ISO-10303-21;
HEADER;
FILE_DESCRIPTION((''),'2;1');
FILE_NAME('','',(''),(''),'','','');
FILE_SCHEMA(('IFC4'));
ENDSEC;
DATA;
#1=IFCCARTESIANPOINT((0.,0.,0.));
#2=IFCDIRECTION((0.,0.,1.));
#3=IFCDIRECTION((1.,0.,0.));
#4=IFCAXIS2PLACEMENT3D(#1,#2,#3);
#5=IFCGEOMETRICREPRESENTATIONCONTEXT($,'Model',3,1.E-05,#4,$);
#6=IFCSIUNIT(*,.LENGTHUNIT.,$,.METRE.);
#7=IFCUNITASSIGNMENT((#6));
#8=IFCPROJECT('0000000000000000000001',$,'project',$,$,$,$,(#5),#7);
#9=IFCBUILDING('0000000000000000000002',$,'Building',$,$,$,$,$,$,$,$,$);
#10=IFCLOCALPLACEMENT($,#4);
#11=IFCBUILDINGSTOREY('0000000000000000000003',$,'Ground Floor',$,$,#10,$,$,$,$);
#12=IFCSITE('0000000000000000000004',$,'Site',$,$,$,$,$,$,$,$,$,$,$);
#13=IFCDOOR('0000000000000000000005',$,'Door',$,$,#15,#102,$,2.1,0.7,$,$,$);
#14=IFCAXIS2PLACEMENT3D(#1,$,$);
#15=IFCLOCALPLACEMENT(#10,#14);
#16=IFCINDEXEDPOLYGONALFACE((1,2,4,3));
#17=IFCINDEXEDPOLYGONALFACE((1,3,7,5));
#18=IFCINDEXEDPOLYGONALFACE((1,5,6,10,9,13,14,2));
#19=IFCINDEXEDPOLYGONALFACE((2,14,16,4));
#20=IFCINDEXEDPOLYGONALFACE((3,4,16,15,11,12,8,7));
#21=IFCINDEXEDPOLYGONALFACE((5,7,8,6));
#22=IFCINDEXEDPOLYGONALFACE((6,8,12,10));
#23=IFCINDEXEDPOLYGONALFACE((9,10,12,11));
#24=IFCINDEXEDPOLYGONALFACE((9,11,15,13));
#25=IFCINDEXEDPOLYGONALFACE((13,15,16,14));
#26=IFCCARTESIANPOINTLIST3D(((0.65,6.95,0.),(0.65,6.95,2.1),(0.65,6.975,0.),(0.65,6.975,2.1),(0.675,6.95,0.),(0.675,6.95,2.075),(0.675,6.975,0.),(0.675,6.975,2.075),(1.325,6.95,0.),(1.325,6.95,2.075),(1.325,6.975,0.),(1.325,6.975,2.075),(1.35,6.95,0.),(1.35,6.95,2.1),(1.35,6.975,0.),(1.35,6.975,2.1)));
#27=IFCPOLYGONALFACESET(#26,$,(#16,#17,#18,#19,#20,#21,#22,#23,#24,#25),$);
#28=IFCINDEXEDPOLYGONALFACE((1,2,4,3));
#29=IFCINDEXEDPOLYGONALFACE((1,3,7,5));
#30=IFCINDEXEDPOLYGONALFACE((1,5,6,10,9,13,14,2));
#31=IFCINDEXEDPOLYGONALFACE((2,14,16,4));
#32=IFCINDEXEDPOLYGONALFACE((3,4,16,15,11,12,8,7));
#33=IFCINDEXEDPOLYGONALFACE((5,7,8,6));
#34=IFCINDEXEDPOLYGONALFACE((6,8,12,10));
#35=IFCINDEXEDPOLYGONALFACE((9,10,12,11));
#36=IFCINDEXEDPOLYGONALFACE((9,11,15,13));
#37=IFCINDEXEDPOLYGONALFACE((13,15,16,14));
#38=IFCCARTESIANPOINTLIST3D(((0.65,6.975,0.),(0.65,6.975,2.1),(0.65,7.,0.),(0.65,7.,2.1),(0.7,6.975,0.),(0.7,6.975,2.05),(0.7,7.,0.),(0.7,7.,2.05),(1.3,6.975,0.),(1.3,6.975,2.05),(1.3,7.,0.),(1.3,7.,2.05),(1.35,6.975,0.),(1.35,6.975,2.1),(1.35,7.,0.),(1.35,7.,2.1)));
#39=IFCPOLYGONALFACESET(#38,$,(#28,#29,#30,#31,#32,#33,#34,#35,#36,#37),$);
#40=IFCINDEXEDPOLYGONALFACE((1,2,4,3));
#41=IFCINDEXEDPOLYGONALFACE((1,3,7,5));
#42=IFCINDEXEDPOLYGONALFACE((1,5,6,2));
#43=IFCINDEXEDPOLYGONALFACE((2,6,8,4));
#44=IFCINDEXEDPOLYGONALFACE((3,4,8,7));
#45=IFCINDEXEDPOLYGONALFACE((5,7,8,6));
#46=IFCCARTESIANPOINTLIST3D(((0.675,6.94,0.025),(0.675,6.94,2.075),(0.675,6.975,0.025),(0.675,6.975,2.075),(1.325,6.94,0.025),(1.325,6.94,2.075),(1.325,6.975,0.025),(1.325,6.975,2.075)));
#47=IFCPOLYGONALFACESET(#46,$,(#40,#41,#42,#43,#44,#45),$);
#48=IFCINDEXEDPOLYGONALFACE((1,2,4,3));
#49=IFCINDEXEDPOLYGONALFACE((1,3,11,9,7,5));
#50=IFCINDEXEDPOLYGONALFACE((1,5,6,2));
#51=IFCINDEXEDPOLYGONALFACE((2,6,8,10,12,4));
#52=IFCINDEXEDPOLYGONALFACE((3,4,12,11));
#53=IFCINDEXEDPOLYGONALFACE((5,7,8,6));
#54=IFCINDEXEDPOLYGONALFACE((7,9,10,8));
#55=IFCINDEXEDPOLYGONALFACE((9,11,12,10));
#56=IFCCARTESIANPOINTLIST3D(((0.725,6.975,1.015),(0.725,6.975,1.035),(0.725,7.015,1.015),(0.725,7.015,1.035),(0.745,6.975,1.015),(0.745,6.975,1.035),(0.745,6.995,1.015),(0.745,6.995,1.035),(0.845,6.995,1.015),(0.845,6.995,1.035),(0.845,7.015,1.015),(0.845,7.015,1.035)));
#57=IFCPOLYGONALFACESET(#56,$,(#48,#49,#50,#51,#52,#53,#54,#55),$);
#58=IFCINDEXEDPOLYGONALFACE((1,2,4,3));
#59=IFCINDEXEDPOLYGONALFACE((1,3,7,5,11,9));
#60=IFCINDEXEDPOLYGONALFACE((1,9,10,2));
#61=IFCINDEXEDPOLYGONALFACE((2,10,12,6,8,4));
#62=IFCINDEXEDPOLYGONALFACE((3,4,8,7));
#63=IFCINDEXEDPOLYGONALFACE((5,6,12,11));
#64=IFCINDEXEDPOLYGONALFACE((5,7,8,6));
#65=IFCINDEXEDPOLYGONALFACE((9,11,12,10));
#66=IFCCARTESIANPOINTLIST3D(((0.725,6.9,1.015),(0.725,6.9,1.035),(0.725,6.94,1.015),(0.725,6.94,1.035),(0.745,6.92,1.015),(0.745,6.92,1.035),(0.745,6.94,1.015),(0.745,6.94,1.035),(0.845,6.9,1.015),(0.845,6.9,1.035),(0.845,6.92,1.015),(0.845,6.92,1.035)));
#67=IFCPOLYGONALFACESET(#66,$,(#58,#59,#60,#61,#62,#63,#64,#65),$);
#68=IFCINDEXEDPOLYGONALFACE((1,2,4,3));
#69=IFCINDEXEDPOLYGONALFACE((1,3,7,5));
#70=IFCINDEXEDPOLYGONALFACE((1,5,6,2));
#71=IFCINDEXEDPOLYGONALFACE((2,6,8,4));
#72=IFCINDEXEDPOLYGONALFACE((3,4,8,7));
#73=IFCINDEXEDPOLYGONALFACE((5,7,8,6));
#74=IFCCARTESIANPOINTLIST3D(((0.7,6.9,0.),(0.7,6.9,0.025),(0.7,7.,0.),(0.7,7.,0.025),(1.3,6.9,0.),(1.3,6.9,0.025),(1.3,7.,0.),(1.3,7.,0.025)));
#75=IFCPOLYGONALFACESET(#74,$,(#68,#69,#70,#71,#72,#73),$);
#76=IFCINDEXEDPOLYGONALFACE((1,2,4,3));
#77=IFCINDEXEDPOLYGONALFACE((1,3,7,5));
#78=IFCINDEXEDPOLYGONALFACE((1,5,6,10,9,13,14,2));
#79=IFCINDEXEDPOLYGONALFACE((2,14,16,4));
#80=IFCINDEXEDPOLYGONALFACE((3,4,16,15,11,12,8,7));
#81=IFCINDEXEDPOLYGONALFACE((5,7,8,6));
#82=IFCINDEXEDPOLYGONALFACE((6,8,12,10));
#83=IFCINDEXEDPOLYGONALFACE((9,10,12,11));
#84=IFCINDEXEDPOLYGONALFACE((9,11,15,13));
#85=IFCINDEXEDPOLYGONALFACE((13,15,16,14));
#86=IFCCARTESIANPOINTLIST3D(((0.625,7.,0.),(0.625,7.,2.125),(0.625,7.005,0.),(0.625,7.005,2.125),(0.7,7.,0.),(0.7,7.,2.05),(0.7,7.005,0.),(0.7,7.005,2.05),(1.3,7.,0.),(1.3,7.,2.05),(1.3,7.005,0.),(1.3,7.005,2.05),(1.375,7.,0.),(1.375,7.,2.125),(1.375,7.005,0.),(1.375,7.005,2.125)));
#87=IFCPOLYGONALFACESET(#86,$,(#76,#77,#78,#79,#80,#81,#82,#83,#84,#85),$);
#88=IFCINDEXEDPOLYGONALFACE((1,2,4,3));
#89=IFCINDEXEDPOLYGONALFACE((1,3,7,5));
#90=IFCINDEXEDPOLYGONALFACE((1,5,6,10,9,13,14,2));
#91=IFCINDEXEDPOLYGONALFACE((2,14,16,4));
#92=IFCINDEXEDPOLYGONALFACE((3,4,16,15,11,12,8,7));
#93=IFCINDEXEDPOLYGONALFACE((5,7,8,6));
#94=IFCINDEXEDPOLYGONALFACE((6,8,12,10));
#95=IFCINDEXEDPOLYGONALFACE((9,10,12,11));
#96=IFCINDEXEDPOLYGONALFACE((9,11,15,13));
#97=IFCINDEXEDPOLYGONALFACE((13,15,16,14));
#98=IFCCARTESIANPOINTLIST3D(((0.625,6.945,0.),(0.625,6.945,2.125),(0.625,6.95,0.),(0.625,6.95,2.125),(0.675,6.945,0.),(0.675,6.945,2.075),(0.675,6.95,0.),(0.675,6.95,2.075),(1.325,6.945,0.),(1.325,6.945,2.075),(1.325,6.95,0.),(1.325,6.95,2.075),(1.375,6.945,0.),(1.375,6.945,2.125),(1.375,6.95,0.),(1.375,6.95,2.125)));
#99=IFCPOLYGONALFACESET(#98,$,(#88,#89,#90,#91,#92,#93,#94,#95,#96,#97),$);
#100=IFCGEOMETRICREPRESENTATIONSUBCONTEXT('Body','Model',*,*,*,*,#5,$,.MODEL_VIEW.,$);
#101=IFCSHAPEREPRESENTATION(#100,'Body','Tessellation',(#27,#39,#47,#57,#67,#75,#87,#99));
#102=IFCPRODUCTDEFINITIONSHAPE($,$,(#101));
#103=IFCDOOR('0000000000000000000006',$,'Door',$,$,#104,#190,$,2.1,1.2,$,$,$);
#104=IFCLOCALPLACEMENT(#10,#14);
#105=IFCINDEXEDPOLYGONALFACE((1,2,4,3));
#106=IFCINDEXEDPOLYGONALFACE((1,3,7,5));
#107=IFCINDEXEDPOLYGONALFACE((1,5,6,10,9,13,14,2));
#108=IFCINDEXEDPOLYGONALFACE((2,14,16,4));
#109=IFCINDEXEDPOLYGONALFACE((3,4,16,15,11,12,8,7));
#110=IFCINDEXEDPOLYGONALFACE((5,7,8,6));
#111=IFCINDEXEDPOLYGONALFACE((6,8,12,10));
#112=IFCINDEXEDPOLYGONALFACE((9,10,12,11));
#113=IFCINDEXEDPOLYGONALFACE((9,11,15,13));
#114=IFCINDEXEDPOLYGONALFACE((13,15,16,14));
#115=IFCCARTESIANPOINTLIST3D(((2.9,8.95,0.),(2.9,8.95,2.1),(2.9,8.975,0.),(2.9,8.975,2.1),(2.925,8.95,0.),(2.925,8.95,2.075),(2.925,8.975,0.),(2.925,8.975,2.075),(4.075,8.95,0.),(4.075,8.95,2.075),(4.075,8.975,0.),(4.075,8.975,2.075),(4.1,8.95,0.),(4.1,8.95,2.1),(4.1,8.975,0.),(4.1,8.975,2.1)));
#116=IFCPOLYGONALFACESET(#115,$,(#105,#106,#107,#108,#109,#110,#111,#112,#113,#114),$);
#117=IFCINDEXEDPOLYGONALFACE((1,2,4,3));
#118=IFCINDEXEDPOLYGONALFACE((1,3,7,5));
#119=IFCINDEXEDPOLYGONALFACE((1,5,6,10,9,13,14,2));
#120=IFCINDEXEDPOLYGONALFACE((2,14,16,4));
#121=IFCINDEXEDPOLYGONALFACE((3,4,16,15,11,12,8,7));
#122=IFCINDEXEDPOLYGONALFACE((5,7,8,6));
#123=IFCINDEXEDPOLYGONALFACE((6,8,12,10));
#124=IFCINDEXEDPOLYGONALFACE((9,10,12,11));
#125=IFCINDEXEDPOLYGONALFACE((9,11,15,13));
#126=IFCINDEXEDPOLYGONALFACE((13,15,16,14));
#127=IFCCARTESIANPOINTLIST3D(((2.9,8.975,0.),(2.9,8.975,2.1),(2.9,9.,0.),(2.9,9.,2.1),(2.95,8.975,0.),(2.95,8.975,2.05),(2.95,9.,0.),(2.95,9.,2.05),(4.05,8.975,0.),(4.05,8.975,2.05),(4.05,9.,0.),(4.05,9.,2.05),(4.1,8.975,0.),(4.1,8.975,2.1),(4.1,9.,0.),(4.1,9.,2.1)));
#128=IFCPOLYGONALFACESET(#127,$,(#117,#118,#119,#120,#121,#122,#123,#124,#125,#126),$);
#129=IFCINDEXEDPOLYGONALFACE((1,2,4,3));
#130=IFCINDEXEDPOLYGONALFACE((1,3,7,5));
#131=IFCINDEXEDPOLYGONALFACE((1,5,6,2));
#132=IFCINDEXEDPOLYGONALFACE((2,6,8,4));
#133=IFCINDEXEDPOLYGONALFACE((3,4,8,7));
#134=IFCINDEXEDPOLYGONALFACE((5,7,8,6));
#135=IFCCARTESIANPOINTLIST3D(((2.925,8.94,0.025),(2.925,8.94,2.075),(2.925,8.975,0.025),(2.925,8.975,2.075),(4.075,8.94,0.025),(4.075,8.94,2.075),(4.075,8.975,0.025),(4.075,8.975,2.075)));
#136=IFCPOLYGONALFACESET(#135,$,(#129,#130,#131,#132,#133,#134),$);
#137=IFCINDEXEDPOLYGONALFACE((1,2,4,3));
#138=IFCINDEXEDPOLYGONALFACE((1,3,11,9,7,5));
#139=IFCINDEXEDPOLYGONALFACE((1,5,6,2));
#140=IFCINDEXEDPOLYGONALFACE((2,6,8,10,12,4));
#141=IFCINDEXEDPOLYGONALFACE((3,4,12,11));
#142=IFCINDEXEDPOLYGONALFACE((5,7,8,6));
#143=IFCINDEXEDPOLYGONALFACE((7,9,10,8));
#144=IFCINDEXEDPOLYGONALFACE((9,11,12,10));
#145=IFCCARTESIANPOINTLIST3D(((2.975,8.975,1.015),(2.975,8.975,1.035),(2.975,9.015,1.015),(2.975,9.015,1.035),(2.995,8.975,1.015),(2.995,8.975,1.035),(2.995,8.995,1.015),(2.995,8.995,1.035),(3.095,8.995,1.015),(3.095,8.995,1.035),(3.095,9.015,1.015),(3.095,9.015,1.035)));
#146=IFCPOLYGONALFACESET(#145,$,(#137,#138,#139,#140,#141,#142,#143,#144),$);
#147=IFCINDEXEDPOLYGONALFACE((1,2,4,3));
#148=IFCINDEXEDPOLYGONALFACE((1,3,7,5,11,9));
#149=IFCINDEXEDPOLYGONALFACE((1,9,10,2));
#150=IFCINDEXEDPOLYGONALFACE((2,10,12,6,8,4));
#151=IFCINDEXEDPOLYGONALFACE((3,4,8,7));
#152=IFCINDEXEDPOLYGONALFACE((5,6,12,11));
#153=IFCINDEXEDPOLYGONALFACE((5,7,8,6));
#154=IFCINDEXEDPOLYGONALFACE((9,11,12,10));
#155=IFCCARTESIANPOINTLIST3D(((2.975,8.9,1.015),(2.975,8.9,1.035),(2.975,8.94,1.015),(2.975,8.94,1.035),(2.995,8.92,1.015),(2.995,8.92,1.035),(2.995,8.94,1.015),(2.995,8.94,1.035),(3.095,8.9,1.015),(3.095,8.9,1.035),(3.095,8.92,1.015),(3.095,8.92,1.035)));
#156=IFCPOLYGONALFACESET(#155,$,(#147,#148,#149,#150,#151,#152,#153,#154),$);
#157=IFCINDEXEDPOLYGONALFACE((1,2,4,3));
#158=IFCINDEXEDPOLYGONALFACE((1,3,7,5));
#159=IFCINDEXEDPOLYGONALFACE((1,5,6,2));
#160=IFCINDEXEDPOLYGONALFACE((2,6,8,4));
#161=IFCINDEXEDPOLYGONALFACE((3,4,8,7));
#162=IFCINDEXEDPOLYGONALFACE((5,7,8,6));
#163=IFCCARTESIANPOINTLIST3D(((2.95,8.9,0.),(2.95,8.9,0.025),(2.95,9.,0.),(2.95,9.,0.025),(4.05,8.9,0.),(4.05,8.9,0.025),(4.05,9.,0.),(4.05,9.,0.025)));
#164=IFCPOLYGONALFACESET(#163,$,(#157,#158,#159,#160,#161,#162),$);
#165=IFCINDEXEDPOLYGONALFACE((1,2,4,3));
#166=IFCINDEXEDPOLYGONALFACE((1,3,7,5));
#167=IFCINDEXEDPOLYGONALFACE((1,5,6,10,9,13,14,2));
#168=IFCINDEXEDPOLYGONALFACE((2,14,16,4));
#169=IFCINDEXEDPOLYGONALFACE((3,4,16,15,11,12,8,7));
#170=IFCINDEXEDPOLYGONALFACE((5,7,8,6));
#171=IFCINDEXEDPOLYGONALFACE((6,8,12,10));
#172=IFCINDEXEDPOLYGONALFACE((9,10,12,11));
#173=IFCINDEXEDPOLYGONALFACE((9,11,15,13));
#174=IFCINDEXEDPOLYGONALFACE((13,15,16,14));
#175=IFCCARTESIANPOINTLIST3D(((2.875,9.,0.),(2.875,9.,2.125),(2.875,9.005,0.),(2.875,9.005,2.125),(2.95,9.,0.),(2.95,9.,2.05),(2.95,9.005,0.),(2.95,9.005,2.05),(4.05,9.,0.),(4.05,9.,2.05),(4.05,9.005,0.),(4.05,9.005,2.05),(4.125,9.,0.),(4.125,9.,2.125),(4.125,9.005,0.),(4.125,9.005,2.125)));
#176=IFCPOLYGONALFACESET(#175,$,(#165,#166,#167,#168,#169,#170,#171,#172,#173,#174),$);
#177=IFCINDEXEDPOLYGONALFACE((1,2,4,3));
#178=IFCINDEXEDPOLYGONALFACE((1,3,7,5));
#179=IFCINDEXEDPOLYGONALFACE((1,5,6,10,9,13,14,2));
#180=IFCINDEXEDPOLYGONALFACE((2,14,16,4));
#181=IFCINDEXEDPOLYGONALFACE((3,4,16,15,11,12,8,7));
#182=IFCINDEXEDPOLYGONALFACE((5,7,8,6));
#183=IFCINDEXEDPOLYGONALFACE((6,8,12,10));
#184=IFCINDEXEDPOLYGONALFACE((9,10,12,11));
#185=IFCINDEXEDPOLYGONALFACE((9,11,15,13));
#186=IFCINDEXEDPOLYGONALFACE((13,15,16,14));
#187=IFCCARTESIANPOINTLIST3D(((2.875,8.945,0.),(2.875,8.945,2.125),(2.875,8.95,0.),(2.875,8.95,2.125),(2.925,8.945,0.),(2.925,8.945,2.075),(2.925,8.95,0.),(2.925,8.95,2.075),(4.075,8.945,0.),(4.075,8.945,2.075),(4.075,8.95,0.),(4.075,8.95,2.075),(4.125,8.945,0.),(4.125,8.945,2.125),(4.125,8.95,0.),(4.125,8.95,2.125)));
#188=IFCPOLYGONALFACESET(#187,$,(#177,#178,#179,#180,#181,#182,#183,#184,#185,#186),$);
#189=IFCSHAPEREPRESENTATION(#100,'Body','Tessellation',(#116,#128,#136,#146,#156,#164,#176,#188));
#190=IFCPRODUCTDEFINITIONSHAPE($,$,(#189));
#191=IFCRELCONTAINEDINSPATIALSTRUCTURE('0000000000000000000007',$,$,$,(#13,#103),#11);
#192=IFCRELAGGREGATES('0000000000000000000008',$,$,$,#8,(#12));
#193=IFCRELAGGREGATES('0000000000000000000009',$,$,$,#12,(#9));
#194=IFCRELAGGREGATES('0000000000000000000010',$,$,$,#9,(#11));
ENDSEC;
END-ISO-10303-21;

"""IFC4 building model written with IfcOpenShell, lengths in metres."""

from ifc_helpers import new_model, si_unit, frame, origin_with_axes, place, context, subcontext, project, spatial, line, indexed_curve, outline, extrude, element, save


model = new_model("IFC4")

# Units and contexts
model_context = context("Model", 3, precision=1e-05, world=origin_with_axes())
body_context = subcontext(model_context, "Body", "Model", "MODEL_VIEW")
ifc_project = project(units=[si_unit("LENGTHUNIT", "METRE")], contexts=[model_context])

# Site, building, storey
site = spatial("IfcSite", under=ifc_project, Name="Site")
building = spatial("IfcBuilding", under=site, Name="Building")
storey_placement = place(None, origin_with_axes())
storey = spatial("IfcBuildingStorey", under=building, at=storey_placement, Name="Ground Floor")

# Doors
door_1_placement = place(storey_placement, frame((1.35, 7.0, 0.0), z_axis=(0.0, 0.0, 1.0), x_axis=(-1.0, 0.0, 0.0)))
element("IfcDoor", 1, at=door_1_placement, inside=storey, Name="Door", OverallHeight=2.1, OverallWidth=0.7, context=body_context, shape_type="SweptSolid", body=[
    extrude(outline(indexed_curve([(0.0, 0.0), (0.0, 2.1), (0.7, 2.1), (0.7, 0.0), (0.675, 0.0), (0.675, 2.075), (0.025, 2.075), (0.025, 0.0)], segments=[line(1, 2, 3, 4, 5, 6, 7, 8, 1)])), frame((0.0, 0.025, 0.0), z_axis=(0.0, -1.0, 0.0), x_axis=(1.0, 0.0, 0.0)), (0.0, 0.0, -1.0), 0.025),
    extrude(outline(indexed_curve([(0.0, 0.0), (0.0, 2.1), (0.7, 2.1), (0.7, 0.0), (0.65, 0.0), (0.65, 2.05), (0.05, 2.05), (0.05, 0.0)], segments=[line(1, 2, 3, 4, 5, 6, 7, 8, 1)])), frame((0.0, 0.0, 0.0), z_axis=(0.0, -1.0, 0.0), x_axis=(1.0, 0.0, 0.0)), (0.0, 0.0, -1.0), 0.025),
    extrude(outline(indexed_curve([(0.0, 0.0), (0.65, 0.0), (0.65, 0.035), (0.0, 0.035)], segments=[line(1, 2, 3, 4, 1)])), frame((0.025, 0.025, 0.025), z_axis=(0.0, 0.0, 1.0), x_axis=(1.0, 0.0, 0.0)), (0.0, 0.0, 1.0), 2.05),
    extrude(outline(indexed_curve([(0.0, 0.0), (0.0, -0.04), (-0.12, -0.04), (-0.12, -0.02), (-0.02, -0.02), (-0.02, 0.0)], segments=[line(1, 2, 3, 4, 5, 6, 1)])), frame((0.625, 0.025, 1.015), z_axis=(0.0, 0.0, 1.0), x_axis=(1.0, 0.0, 0.0)), (0.0, 0.0, 1.0), 0.02),
    extrude(outline(indexed_curve([(0.0, 0.0), (0.0, 0.04), (-0.12, 0.04), (-0.12, 0.02), (-0.02, 0.02), (-0.02, 0.0)], segments=[line(1, 2, 3, 4, 5, 6, 1)])), frame((0.625, 0.06, 1.015), z_axis=(0.0, 0.0, 1.0), x_axis=(1.0, 0.0, 0.0)), (0.0, 0.0, 1.0), 0.02),
    extrude(outline(indexed_curve([(0.0, 0.0), (0.6, 0.0), (0.6, 0.1), (0.0, 0.1)], segments=[line(1, 2, 3, 4, 1)])), frame((0.05, 0.0, 0.0), z_axis=(0.0, 0.0, 1.0), x_axis=(1.0, 0.0, 0.0)), (0.0, 0.0, 1.0), 0.025),
    extrude(outline(indexed_curve([(0.0, 0.0), (0.0, 2.125), (0.75, 2.125), (0.75, 0.0), (0.675, 0.0), (0.675, 2.05), (0.075, 2.05), (0.075, 0.0)], segments=[line(1, 2, 3, 4, 5, 6, 7, 8, 1)])), frame((-0.025, -0.005, 0.0), z_axis=(0.0, -1.0, 0.0), x_axis=(1.0, 0.0, 0.0)), (0.0, 0.0, -1.0), 0.005),
    extrude(outline(indexed_curve([(0.0, 0.0), (0.0, 2.125), (0.75, 2.125), (0.75, 0.0), (0.7, 0.0), (0.7, 2.075), (0.05, 2.075), (0.05, 0.0)], segments=[line(1, 2, 3, 4, 5, 6, 7, 8, 1)])), frame((-0.025, 0.05, 0.0), z_axis=(0.0, -1.0, 0.0), x_axis=(1.0, 0.0, 0.0)), (0.0, 0.0, -1.0), 0.005),
])
door_2_placement = place(storey_placement, frame((4.1, 9.0, 0.0), z_axis=(0.0, 0.0, 1.0), x_axis=(-1.0, 0.0, 0.0)))
element("IfcDoor", 2, at=door_2_placement, inside=storey, Name="Door", OverallHeight=2.1, OverallWidth=1.2, context=body_context, shape_type="SweptSolid", body=[
    extrude(outline(indexed_curve([(0.0, 0.0), (0.0, 2.1), (1.2, 2.1), (1.2, 0.0), (1.175, 0.0), (1.175, 2.075), (0.025, 2.075), (0.025, 0.0)], segments=[line(1, 2, 3, 4, 5, 6, 7, 8, 1)])), frame((0.0, 0.025, 0.0), z_axis=(0.0, -1.0, 0.0), x_axis=(1.0, 0.0, 0.0)), (0.0, 0.0, -1.0), 0.025),
    extrude(outline(indexed_curve([(0.0, 0.0), (0.0, 2.1), (1.2, 2.1), (1.2, 0.0), (1.15, 0.0), (1.15, 2.05), (0.05, 2.05), (0.05, 0.0)], segments=[line(1, 2, 3, 4, 5, 6, 7, 8, 1)])), frame((0.0, 0.0, 0.0), z_axis=(0.0, -1.0, 0.0), x_axis=(1.0, 0.0, 0.0)), (0.0, 0.0, -1.0), 0.025),
    extrude(outline(indexed_curve([(0.0, 0.0), (1.15, 0.0), (1.15, 0.035), (0.0, 0.035)], segments=[line(1, 2, 3, 4, 1)])), frame((0.025, 0.025, 0.025), z_axis=(0.0, 0.0, 1.0), x_axis=(1.0, 0.0, 0.0)), (0.0, 0.0, 1.0), 2.05),
    extrude(outline(indexed_curve([(0.0, 0.0), (0.0, -0.04), (-0.12, -0.04), (-0.12, -0.02), (-0.02, -0.02), (-0.02, 0.0)], segments=[line(1, 2, 3, 4, 5, 6, 1)])), frame((1.125, 0.025, 1.015), z_axis=(0.0, 0.0, 1.0), x_axis=(1.0, 0.0, 0.0)), (0.0, 0.0, 1.0), 0.02),
    extrude(outline(indexed_curve([(0.0, 0.0), (0.0, 0.04), (-0.12, 0.04), (-0.12, 0.02), (-0.02, 0.02), (-0.02, 0.0)], segments=[line(1, 2, 3, 4, 5, 6, 1)])), frame((1.125, 0.06, 1.015), z_axis=(0.0, 0.0, 1.0), x_axis=(1.0, 0.0, 0.0)), (0.0, 0.0, 1.0), 0.02),
    extrude(outline(indexed_curve([(0.0, 0.0), (1.1, 0.0), (1.1, 0.1), (0.0, 0.1)], segments=[line(1, 2, 3, 4, 1)])), frame((0.05, 0.0, 0.0), z_axis=(0.0, 0.0, 1.0), x_axis=(1.0, 0.0, 0.0)), (0.0, 0.0, 1.0), 0.025),
    extrude(outline(indexed_curve([(0.0, 0.0), (0.0, 2.125), (1.25, 2.125), (1.25, 0.0), (1.175, 0.0), (1.175, 2.05), (0.075, 2.05), (0.075, 0.0)], segments=[line(1, 2, 3, 4, 5, 6, 7, 8, 1)])), frame((-0.025, -0.005, 0.0), z_axis=(0.0, -1.0, 0.0), x_axis=(1.0, 0.0, 0.0)), (0.0, 0.0, -1.0), 0.005),
    extrude(outline(indexed_curve([(0.0, 0.0), (0.0, 2.125), (1.25, 2.125), (1.25, 0.0), (1.2, 0.0), (1.2, 2.075), (0.05, 2.075), (0.05, 0.0)], segments=[line(1, 2, 3, 4, 5, 6, 7, 8, 1)])), frame((-0.025, 0.05, 0.0), z_axis=(0.0, -1.0, 0.0), x_axis=(1.0, 0.0, 0.0)), (0.0, 0.0, -1.0), 0.005),
])

save(model, "model.ifc")
